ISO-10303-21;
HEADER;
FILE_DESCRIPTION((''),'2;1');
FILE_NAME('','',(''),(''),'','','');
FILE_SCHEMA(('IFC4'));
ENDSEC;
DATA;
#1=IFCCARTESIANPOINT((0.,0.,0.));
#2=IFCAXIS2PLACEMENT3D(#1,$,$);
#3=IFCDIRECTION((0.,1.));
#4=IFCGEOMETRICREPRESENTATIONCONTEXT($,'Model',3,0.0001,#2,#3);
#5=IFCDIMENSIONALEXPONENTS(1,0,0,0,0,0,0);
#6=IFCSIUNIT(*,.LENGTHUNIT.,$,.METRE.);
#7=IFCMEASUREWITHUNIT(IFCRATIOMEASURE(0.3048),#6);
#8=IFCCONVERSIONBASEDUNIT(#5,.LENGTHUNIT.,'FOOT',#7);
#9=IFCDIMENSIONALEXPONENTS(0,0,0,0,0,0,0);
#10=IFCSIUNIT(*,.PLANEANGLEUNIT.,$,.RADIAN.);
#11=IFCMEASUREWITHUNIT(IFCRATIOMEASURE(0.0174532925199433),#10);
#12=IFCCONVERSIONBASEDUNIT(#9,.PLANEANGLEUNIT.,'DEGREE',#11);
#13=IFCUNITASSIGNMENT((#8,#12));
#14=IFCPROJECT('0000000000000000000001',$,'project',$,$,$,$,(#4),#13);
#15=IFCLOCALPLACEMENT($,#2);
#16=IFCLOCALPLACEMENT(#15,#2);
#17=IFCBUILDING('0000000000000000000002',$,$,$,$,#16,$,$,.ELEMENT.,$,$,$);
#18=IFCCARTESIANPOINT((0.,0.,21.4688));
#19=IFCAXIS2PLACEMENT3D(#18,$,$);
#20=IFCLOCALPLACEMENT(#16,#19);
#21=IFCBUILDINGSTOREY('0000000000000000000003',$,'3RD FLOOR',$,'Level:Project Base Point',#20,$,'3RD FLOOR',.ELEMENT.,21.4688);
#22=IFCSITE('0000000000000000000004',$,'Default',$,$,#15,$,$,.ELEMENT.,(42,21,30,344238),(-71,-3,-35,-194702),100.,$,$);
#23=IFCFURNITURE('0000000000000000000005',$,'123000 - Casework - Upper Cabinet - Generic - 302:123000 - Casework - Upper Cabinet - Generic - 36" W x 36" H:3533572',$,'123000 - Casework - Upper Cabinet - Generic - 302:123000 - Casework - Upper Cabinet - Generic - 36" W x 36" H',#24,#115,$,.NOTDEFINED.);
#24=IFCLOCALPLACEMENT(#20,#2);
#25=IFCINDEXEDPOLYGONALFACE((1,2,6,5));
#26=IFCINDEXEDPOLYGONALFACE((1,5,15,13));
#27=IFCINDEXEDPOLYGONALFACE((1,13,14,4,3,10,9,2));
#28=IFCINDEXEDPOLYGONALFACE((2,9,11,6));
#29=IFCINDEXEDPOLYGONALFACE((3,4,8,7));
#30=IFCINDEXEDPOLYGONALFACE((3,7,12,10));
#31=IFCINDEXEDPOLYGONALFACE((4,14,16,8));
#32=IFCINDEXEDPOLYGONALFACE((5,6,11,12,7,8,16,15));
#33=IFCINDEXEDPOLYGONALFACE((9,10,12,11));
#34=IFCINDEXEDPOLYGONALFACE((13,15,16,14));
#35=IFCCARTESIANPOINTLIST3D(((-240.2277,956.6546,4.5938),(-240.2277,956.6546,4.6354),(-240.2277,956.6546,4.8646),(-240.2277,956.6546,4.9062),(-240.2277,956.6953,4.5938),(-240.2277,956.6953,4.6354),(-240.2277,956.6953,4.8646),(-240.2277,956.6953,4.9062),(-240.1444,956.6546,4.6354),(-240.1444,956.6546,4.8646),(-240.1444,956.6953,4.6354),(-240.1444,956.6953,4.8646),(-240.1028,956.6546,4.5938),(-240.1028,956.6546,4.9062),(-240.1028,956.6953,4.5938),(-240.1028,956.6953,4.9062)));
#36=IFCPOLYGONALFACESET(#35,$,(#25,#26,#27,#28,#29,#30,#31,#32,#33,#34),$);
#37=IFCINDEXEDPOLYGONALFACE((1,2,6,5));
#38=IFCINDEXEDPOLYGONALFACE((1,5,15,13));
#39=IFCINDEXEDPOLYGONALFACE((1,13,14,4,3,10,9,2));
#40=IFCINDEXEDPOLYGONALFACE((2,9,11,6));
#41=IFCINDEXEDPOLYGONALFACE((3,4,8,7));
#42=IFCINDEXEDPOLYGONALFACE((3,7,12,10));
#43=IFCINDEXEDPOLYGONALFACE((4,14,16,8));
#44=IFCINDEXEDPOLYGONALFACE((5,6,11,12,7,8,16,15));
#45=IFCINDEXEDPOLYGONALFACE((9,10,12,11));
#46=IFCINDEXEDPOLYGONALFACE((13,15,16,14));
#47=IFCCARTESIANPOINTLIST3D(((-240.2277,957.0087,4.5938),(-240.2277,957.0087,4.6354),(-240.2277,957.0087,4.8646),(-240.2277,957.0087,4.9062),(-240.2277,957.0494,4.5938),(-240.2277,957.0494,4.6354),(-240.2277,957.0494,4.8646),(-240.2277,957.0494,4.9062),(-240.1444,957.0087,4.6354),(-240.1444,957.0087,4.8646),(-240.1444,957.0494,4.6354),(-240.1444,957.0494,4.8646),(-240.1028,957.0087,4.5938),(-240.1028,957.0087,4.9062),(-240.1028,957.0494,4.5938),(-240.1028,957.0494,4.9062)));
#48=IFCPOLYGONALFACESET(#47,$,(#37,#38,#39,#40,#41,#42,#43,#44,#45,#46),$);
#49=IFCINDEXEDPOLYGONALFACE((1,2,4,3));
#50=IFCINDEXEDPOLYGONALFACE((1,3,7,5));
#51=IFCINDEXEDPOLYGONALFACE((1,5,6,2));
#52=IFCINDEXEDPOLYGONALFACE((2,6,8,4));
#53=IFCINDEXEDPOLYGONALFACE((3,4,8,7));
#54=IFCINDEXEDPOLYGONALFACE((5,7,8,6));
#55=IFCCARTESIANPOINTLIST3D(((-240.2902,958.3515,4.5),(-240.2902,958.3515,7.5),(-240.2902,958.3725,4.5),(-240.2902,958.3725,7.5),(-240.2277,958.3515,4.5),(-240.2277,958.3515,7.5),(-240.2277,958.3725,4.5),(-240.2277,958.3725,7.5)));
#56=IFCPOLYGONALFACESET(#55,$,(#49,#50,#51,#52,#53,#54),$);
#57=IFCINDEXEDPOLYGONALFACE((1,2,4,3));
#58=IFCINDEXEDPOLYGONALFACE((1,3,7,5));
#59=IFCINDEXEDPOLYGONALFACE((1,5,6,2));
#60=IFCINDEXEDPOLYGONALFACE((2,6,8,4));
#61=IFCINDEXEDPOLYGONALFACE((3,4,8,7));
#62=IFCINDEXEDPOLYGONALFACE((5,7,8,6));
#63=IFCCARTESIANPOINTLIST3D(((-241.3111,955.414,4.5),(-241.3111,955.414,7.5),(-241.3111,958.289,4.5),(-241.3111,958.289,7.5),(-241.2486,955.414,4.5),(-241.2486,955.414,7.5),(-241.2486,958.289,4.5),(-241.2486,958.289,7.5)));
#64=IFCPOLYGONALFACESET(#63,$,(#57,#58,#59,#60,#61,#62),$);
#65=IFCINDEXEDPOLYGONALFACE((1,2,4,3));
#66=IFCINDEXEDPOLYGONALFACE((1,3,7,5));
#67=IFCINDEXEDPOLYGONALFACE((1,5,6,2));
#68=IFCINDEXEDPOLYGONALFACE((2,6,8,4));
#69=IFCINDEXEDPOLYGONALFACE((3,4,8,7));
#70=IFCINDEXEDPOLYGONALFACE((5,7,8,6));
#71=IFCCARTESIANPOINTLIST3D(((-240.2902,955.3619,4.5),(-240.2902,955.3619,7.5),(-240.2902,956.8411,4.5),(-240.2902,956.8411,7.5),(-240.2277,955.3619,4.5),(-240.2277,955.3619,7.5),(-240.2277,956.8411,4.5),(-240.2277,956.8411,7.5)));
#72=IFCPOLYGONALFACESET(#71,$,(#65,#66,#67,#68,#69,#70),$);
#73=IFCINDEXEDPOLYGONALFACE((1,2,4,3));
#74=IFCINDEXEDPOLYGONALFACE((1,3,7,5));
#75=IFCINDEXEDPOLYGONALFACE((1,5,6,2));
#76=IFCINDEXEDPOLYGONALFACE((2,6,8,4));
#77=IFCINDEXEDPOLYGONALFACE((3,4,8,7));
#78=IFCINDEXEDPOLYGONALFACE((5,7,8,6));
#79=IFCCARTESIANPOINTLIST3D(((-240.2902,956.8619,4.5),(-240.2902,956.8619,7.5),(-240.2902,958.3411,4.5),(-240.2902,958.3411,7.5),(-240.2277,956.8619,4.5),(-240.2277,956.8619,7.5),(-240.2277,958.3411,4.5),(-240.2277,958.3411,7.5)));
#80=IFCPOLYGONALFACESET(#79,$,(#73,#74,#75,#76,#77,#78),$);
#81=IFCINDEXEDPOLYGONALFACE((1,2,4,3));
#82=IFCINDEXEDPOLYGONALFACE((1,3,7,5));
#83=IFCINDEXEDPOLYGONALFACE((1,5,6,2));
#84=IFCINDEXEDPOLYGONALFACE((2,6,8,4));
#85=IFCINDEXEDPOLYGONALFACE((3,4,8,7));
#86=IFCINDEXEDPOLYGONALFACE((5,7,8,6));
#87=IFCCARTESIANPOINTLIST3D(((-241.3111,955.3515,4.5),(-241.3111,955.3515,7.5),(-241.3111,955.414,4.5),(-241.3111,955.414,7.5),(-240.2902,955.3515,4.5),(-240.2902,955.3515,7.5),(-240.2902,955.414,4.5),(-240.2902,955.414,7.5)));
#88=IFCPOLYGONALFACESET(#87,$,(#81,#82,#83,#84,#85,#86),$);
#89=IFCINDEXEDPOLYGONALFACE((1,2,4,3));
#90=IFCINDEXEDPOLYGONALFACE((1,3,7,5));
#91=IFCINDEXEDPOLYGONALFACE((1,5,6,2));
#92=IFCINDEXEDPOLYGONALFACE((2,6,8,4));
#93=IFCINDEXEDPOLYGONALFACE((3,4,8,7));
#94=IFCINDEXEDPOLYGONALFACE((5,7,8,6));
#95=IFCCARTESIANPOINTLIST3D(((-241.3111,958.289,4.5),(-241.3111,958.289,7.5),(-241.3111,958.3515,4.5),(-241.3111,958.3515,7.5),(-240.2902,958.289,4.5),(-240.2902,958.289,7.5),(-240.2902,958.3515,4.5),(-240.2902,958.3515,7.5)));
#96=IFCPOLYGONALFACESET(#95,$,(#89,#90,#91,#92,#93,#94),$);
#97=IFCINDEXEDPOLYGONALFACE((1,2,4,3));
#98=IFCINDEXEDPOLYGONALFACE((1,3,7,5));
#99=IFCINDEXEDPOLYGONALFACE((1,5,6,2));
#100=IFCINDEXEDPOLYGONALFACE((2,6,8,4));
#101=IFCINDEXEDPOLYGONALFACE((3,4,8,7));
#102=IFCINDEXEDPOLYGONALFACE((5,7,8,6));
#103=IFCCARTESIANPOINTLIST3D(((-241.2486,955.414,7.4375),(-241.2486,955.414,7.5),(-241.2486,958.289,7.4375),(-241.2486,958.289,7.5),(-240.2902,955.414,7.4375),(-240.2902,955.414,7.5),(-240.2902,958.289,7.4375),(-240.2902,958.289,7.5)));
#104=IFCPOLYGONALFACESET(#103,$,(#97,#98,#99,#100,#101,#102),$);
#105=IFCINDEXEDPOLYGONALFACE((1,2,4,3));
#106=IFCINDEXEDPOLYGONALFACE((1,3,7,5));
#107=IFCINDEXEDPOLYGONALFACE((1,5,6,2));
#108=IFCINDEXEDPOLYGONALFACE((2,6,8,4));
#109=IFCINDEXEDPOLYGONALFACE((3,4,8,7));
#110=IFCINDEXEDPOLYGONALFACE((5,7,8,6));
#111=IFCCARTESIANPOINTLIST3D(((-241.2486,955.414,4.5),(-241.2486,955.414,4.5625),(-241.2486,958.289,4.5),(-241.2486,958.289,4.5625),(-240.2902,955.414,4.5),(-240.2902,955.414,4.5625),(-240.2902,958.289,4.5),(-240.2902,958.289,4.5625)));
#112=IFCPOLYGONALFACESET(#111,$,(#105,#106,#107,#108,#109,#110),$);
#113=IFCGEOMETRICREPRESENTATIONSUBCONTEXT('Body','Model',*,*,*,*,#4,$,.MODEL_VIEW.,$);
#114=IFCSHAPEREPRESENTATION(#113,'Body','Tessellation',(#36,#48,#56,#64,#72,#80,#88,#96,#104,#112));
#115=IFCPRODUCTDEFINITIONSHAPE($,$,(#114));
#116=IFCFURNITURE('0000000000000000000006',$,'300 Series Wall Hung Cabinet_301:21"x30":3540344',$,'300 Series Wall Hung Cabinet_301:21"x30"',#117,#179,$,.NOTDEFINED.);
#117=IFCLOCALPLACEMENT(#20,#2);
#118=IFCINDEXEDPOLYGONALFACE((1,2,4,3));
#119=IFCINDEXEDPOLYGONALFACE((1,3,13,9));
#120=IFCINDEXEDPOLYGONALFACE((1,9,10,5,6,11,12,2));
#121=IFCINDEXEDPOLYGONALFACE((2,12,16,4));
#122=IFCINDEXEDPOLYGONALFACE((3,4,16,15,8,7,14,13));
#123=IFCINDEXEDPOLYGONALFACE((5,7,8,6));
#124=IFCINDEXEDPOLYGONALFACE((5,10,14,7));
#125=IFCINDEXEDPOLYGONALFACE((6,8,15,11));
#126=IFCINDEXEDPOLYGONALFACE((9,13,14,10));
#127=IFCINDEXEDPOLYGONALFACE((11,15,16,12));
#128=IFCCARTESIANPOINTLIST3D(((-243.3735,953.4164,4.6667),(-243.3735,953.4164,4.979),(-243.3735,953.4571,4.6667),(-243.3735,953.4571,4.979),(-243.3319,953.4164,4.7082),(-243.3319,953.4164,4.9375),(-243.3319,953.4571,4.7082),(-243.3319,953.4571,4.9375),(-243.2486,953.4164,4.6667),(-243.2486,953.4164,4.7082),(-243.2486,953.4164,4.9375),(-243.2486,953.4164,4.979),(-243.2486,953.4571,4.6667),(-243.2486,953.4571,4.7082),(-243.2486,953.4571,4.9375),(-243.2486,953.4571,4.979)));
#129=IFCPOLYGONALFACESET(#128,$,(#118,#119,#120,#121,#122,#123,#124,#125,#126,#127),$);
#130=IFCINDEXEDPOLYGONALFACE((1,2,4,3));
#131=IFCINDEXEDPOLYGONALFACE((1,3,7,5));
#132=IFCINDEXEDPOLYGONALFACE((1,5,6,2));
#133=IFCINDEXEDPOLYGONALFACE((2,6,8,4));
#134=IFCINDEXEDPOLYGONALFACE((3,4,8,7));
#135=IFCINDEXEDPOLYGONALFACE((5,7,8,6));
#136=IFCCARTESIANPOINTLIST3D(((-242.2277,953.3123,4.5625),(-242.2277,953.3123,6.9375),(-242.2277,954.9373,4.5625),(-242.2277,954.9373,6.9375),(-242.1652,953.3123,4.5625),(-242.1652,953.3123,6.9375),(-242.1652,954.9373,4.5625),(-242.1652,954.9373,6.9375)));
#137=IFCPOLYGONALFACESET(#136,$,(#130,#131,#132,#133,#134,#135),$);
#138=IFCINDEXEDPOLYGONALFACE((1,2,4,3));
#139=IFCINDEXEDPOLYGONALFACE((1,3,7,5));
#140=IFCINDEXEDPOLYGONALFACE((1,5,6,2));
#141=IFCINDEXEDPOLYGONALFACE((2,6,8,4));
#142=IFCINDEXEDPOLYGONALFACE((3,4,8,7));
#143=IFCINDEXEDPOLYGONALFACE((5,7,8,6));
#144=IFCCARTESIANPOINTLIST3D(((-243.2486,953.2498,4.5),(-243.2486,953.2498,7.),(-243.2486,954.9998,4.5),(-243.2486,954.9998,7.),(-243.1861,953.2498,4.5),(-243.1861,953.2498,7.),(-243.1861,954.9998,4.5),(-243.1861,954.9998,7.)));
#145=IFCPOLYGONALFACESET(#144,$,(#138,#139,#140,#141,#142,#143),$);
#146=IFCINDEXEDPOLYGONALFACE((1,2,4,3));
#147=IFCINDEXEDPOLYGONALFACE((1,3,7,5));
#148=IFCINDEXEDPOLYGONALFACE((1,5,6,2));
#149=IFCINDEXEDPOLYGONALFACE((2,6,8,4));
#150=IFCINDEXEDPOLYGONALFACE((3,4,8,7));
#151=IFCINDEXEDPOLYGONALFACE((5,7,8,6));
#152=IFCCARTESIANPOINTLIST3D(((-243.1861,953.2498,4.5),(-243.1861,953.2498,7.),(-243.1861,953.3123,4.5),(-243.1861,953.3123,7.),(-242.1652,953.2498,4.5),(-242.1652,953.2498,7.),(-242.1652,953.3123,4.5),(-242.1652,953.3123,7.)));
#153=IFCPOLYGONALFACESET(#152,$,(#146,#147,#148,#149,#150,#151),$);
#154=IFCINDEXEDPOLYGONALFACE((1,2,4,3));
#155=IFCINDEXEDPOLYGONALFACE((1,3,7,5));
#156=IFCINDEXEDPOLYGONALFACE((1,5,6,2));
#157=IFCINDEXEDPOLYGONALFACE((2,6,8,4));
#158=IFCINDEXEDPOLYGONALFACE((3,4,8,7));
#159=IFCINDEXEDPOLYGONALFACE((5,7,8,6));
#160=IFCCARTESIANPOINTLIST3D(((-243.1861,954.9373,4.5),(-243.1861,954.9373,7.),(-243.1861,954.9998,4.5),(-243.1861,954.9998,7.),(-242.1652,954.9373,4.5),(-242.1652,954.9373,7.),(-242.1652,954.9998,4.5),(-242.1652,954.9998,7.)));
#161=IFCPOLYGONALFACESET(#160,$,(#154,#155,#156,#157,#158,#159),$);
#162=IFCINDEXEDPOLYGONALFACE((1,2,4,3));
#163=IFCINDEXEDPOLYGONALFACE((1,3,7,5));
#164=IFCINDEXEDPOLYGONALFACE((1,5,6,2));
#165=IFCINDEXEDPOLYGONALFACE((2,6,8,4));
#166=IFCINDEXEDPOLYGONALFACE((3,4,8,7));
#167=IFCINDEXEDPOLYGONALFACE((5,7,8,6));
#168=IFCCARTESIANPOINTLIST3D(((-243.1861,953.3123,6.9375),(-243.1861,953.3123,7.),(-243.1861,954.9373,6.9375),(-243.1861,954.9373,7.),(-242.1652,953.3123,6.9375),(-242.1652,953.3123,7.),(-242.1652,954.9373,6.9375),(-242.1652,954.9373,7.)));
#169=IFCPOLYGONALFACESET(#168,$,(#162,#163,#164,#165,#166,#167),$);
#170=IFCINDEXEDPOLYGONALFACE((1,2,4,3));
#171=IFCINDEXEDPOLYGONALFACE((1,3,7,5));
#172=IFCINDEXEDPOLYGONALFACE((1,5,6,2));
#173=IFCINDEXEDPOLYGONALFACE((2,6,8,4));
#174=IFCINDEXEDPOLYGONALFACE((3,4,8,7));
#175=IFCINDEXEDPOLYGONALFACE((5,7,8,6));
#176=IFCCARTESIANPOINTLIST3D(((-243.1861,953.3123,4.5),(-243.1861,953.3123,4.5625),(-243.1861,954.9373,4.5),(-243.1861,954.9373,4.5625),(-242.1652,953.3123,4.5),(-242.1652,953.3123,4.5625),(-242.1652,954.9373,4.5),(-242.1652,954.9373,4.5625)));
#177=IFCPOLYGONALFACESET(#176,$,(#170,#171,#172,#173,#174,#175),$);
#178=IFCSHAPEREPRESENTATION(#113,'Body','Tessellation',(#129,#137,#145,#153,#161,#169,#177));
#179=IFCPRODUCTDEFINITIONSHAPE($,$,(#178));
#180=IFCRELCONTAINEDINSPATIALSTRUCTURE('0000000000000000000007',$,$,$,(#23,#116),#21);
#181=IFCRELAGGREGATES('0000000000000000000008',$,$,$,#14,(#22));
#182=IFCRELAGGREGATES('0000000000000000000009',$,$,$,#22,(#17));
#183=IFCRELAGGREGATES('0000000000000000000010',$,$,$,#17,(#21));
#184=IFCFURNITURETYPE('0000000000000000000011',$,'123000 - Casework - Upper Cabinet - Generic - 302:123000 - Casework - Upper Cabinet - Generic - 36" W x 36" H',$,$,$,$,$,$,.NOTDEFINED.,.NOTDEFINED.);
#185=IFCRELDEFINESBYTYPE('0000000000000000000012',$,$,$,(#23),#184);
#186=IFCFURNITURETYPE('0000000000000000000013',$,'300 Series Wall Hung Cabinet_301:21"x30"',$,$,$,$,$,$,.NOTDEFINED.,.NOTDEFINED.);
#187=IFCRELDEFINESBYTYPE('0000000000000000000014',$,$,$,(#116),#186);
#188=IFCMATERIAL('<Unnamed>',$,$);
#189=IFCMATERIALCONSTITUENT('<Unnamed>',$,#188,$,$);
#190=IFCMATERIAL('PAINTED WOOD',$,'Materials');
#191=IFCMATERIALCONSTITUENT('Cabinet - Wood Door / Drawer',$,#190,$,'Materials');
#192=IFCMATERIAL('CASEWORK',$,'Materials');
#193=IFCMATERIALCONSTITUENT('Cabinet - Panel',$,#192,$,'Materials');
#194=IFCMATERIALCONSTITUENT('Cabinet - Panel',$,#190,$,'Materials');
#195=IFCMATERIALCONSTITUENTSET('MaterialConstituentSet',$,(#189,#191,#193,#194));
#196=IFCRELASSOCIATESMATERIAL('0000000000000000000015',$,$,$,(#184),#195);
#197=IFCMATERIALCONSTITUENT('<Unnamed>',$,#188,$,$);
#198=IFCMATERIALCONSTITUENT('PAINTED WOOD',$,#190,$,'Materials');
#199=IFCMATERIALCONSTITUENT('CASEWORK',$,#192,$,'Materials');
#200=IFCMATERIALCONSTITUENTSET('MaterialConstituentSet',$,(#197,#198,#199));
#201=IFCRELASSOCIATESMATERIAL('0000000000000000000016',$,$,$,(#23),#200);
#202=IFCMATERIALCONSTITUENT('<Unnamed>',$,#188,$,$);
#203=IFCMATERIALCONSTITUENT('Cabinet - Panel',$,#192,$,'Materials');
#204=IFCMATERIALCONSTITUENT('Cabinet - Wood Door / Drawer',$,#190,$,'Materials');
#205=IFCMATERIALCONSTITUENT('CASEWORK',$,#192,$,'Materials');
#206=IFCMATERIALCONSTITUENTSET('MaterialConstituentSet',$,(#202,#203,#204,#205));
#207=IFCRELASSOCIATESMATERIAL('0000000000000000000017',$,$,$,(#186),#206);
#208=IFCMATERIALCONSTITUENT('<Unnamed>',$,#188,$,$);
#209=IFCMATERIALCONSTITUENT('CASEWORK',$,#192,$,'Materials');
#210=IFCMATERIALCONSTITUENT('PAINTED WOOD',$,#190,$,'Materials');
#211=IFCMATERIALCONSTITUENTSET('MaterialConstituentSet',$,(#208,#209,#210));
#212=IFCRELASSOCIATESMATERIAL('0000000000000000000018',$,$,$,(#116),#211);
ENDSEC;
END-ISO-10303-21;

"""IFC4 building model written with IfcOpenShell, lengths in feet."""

from ifc_helpers import new_model, entity, si_unit, converted_unit, direction, frame, frame_2d, origin, origin_2d_with_axis, place, context, subcontext, project, spatial, polyline, rectangle, outline, extrude, source, transform, mapped, material, constituent, constituent_set, type_object, type_shapes, element, save


model = new_model("IFC4")

# Units and contexts
model_context = context("Model", 3, precision=0.0001, world=origin(), true_north=direction((0.0, 1.0)))
body_context = subcontext(model_context, "Body", "Model", "MODEL_VIEW")
ifc_project = project(units=[converted_unit("LENGTHUNIT", "FOOT", entity("IfcRatioMeasure", 0.3048), si_unit("LENGTHUNIT", "METRE"), dimensions=[1, 0, 0, 0, 0, 0, 0]), converted_unit("PLANEANGLEUNIT", "DEGREE", entity("IfcRatioMeasure", 0.0174532925199433), si_unit("PLANEANGLEUNIT", "RADIAN"), dimensions=[0, 0, 0, 0, 0, 0, 0])], contexts=[model_context])

# Site, building, storey
site_placement = place(None, origin())
site = spatial("IfcSite", under=ifc_project, at=site_placement, Name="Default", CompositionType="ELEMENT", RefLatitude=(42, 21, 30, 344238), RefLongitude=(-71, -3, -35, -194702), RefElevation=100.0)
building_placement = place(site_placement, origin())
building = spatial("IfcBuilding", under=site, at=building_placement, CompositionType="ELEMENT")
storey_placement = place(building_placement, frame((0.0, 0.0, 21.4688)))
storey = spatial("IfcBuildingStorey", under=building, at=storey_placement, Name="3RD FLOOR", ObjectType="Level:Project Base Point", LongName="3RD FLOOR", CompositionType="ELEMENT", Elevation=21.4688)

# Furniture
ifc_material_1 = material(Name="PAINTED WOOD", Category="Materials")
ifc_material_2 = material(Name="CASEWORK", Category="Materials")
ifc_material_3 = material(Name="<Unnamed>")
ifc_constituent_1 = constituent(ifc_material_3, Name="<Unnamed>")
ifc_constituent_2 = constituent(ifc_material_1, Name="PAINTED WOOD", Category="Materials")
ifc_constituent_3 = constituent(ifc_material_2, Name="CASEWORK", Category="Materials")
ifc_constituent_set_1 = constituent_set(constituents=[ifc_constituent_1, ifc_constituent_2, ifc_constituent_3], Name="MaterialConstituentSet")
ifc_constituent_4 = constituent(ifc_material_3, Name="<Unnamed>")
ifc_constituent_5 = constituent(ifc_material_1, Name="Cabinet - Wood Door / Drawer", Category="Materials")
ifc_constituent_6 = constituent(ifc_material_2, Name="Cabinet - Panel", Category="Materials")
ifc_constituent_7 = constituent(ifc_material_1, Name="Cabinet - Panel", Category="Materials")
ifc_constituent_set_2 = constituent_set(constituents=[ifc_constituent_4, ifc_constituent_5, ifc_constituent_6, ifc_constituent_7], Name="MaterialConstituentSet")
furniture_type_1 = type_object("IfcFurnitureType", Name="123000 - Casework - Upper Cabinet - Generic - 302:123000 - Casework - Upper Cabinet - Generic - 36\" W x 36\" H", AssemblyPlace="NOTDEFINED", PredefinedType="NOTDEFINED", material=ifc_constituent_set_2)
shared_shape_1 = source(origin(), body_context, "Body", "SweptSolid", [
    extrude(outline(polyline([(0.1146, -0.0521), (0.1562, -0.0521), (0.1562, 0.0729), (-0.1562, 0.0729), (-0.1562, -0.0521), (-0.1146, -0.0521), (-0.1146, 0.0313), (0.1146, 0.0313), (0.1146, -0.0521)])), frame((1.303, 0.0729, 0.25), z_axis=(1.0, 0.0, 0.0), x_axis=(0.0, 0.0, 1.0)), (0.0, 0.0, 1.0), 0.0407),
    extrude(outline(polyline([(0.1146, -0.0521), (0.1562, -0.0521), (0.1562, 0.0729), (-0.1562, 0.0729), (-0.1562, -0.0521), (-0.1146, -0.0521), (-0.1146, 0.0313), (0.1146, 0.0313), (0.1146, -0.0521)])), frame((1.6572, 0.0729, 0.25), z_axis=(1.0, 0.0, 0.0), x_axis=(0.0, 0.0, 1.0)), (0.0, 0.0, 1.0), 0.0407),
    extrude(rectangle(XDim=0.0625, YDim=0.021, at=frame_2d((0.0, 0.0), x_axis=(1.0, 0.0))), frame((3.0105, 0.1562, 0.0), z_axis=(0.0, 0.0, 1.0), x_axis=(0.0, -1.0, 0.0)), (0.0, 0.0, 1.0), 3.0),
    extrude(rectangle(XDim=0.0625, YDim=2.875, at=origin_2d_with_axis()), frame((1.5, 1.177, 0.0), z_axis=(0.0, 0.0, 1.0), x_axis=(0.0, 1.0, 0.0)), (0.0, 0.0, 1.0), 3.0),
    extrude(rectangle(XDim=0.0625, YDim=1.4792, at=frame_2d((0.0, 0.0), x_axis=(1.0, 0.0))), frame((0.75, 0.1562, 0.0), z_axis=(0.0, 0.0, 1.0), x_axis=(0.0, -1.0, 0.0)), (0.0, 0.0, 1.0), 3.0),
    extrude(rectangle(XDim=0.0625, YDim=1.4792, at=origin_2d_with_axis()), frame((2.25, 0.1562, 0.0), z_axis=(0.0, 0.0, 1.0), x_axis=(0.0, -1.0, 0.0)), (0.0, 0.0, 1.0), 3.0),
    extrude(rectangle(XDim=0.0625, YDim=1.0208, at=origin_2d_with_axis()), frame((0.0312, 0.6979, 0.0), z_axis=(0.0, 0.0, 1.0), x_axis=(-1.0, 0.0, 0.0)), (0.0, 0.0, 1.0), 3.0),
    extrude(rectangle(XDim=0.0625, YDim=1.0208, at=origin_2d_with_axis()), frame((2.9688, 0.6979, 0.0), z_axis=(0.0, 0.0, 1.0), x_axis=(-1.0, 0.0, 0.0)), (0.0, 0.0, 1.0), 3.0),
    extrude(rectangle(XDim=2.875, YDim=0.9583, at=frame_2d((0.0, 0.0), x_axis=(1.0, 0.0))), frame((1.5, 0.6666, 2.9375), z_axis=(0.0, 0.0, 1.0), x_axis=(-1.0, 0.0, 0.0)), (0.0, 0.0, 1.0), 0.0625),
    extrude(rectangle(XDim=2.875, YDim=0.9583, at=frame_2d((0.0, 0.0), x_axis=(1.0, 0.0))), frame((1.5, 0.6666, 0.0), z_axis=(0.0, 0.0, 1.0), x_axis=(-1.0, 0.0, 0.0)), (0.0, 0.0, 1.0), 0.0625),
])
type_shapes(furniture_type_1, [shared_shape_1])
furniture_1_placement = place(storey_placement, frame((-240.1028, 955.3515, 4.5), z_axis=(0.0, 0.0, 1.0), x_axis=(0.0, 1.0, 0.0)))
element("IfcFurniture", 1, at=furniture_1_placement, inside=storey, type_object=furniture_type_1, material=ifc_constituent_set_1, Name="123000 - Casework - Upper Cabinet - Generic - 302:123000 - Casework - Upper Cabinet - Generic - 36\" W x 36\" H:3533572", ObjectType="123000 - Casework - Upper Cabinet - Generic - 302:123000 - Casework - Upper Cabinet - Generic - 36\" W x 36\" H", PredefinedType="NOTDEFINED", context=body_context, shape_type="MappedRepresentation", body=[
    mapped(shared_shape_1, transform((0.0, 0.0, 0.0), scale=1.0)),
])
ifc_constituent_8 = constituent(ifc_material_3, Name="<Unnamed>")
ifc_constituent_9 = constituent(ifc_material_2, Name="CASEWORK", Category="Materials")
ifc_constituent_10 = constituent(ifc_material_1, Name="PAINTED WOOD", Category="Materials")
ifc_constituent_set_3 = constituent_set(constituents=[ifc_constituent_8, ifc_constituent_9, ifc_constituent_10], Name="MaterialConstituentSet")
ifc_constituent_11 = constituent(ifc_material_3, Name="<Unnamed>")
ifc_constituent_12 = constituent(ifc_material_2, Name="Cabinet - Panel", Category="Materials")
ifc_constituent_13 = constituent(ifc_material_1, Name="Cabinet - Wood Door / Drawer", Category="Materials")
ifc_constituent_14 = constituent(ifc_material_2, Name="CASEWORK", Category="Materials")
ifc_constituent_set_4 = constituent_set(constituents=[ifc_constituent_11, ifc_constituent_12, ifc_constituent_13, ifc_constituent_14], Name="MaterialConstituentSet")
furniture_type_2 = type_object("IfcFurnitureType", Name="300 Series Wall Hung Cabinet_301:21\"x30\"", AssemblyPlace="NOTDEFINED", PredefinedType="NOTDEFINED", material=ifc_constituent_set_4)
shared_shape_2 = source(origin(), body_context, "Body", "SweptSolid", [
    extrude(outline(polyline([(-0.0521, -0.1146), (-0.0521, -0.1562), (0.0729, -0.1562), (0.0729, 0.1562), (-0.0521, 0.1562), (-0.0521, 0.1146), (0.0313, 0.1146), (0.0313, -0.1146), (-0.0521, -0.1146)])), frame((0.1667, 1.1354, 0.3229), z_axis=(-1.0, 0.0, 0.0), x_axis=(0.0, 1.0, 0.0)), (0.0, 0.0, -1.0), 0.0407),
    extrude(rectangle(XDim=0.0625, YDim=1.625, at=origin_2d_with_axis()), frame((0.875, 0.0313, 0.0625), z_axis=(0.0, 0.0, 1.0), x_axis=(0.0, 1.0, 0.0)), (0.0, 0.0, 1.0), 2.375),
    extrude(rectangle(XDim=0.0625, YDim=1.75, at=origin_2d_with_axis()), frame((0.875, 1.0521, 0.0), z_axis=(0.0, 0.0, 1.0), x_axis=(0.0, 1.0, 0.0)), (0.0, 0.0, 1.0), 2.5),
    extrude(rectangle(XDim=0.0625, YDim=1.0208, at=frame_2d((0.0, 0.0), x_axis=(1.0, 0.0))), frame((0.0313, 0.5104, 0.0)), (0.0, 0.0, 1.0), 2.5),
    extrude(rectangle(XDim=0.0625, YDim=1.0208, at=frame_2d((0.0, 0.0), x_axis=(1.0, 0.0))), frame((1.7188, 0.5104, 0.0)), (0.0, 0.0, 1.0), 2.5),
    extrude(rectangle(XDim=1.625, YDim=1.0208, at=frame_2d((0.0, 0.0), x_axis=(1.0, 0.0))), frame((0.875, 0.5104, 2.4375), z_axis=(0.0, 0.0, 1.0), x_axis=(-1.0, 0.0, 0.0)), (0.0, 0.0, 1.0), 0.0625),
    extrude(rectangle(XDim=1.625, YDim=1.0208, at=origin_2d_with_axis()), frame((0.875, 0.5104, 0.0), z_axis=(0.0, 0.0, 1.0), x_axis=(-1.0, 0.0, 0.0)), (0.0, 0.0, 1.0), 0.0625),
])
type_shapes(furniture_type_2, [shared_shape_2])
furniture_2_placement = place(storey_placement, frame((-242.1652, 953.2498, 4.5), z_axis=(0.0, 0.0, 1.0), x_axis=(0.0, 1.0, 0.0)))
element("IfcFurniture", 2, at=furniture_2_placement, inside=storey, type_object=furniture_type_2, material=ifc_constituent_set_3, Name="300 Series Wall Hung Cabinet_301:21\"x30\":3540344", ObjectType="300 Series Wall Hung Cabinet_301:21\"x30\"", PredefinedType="NOTDEFINED", context=body_context, shape_type="MappedRepresentation", body=[
    mapped(shared_shape_2, transform((0.0, 0.0, 0.0), scale=1.0)),
])

save(model, "model.ifc")
